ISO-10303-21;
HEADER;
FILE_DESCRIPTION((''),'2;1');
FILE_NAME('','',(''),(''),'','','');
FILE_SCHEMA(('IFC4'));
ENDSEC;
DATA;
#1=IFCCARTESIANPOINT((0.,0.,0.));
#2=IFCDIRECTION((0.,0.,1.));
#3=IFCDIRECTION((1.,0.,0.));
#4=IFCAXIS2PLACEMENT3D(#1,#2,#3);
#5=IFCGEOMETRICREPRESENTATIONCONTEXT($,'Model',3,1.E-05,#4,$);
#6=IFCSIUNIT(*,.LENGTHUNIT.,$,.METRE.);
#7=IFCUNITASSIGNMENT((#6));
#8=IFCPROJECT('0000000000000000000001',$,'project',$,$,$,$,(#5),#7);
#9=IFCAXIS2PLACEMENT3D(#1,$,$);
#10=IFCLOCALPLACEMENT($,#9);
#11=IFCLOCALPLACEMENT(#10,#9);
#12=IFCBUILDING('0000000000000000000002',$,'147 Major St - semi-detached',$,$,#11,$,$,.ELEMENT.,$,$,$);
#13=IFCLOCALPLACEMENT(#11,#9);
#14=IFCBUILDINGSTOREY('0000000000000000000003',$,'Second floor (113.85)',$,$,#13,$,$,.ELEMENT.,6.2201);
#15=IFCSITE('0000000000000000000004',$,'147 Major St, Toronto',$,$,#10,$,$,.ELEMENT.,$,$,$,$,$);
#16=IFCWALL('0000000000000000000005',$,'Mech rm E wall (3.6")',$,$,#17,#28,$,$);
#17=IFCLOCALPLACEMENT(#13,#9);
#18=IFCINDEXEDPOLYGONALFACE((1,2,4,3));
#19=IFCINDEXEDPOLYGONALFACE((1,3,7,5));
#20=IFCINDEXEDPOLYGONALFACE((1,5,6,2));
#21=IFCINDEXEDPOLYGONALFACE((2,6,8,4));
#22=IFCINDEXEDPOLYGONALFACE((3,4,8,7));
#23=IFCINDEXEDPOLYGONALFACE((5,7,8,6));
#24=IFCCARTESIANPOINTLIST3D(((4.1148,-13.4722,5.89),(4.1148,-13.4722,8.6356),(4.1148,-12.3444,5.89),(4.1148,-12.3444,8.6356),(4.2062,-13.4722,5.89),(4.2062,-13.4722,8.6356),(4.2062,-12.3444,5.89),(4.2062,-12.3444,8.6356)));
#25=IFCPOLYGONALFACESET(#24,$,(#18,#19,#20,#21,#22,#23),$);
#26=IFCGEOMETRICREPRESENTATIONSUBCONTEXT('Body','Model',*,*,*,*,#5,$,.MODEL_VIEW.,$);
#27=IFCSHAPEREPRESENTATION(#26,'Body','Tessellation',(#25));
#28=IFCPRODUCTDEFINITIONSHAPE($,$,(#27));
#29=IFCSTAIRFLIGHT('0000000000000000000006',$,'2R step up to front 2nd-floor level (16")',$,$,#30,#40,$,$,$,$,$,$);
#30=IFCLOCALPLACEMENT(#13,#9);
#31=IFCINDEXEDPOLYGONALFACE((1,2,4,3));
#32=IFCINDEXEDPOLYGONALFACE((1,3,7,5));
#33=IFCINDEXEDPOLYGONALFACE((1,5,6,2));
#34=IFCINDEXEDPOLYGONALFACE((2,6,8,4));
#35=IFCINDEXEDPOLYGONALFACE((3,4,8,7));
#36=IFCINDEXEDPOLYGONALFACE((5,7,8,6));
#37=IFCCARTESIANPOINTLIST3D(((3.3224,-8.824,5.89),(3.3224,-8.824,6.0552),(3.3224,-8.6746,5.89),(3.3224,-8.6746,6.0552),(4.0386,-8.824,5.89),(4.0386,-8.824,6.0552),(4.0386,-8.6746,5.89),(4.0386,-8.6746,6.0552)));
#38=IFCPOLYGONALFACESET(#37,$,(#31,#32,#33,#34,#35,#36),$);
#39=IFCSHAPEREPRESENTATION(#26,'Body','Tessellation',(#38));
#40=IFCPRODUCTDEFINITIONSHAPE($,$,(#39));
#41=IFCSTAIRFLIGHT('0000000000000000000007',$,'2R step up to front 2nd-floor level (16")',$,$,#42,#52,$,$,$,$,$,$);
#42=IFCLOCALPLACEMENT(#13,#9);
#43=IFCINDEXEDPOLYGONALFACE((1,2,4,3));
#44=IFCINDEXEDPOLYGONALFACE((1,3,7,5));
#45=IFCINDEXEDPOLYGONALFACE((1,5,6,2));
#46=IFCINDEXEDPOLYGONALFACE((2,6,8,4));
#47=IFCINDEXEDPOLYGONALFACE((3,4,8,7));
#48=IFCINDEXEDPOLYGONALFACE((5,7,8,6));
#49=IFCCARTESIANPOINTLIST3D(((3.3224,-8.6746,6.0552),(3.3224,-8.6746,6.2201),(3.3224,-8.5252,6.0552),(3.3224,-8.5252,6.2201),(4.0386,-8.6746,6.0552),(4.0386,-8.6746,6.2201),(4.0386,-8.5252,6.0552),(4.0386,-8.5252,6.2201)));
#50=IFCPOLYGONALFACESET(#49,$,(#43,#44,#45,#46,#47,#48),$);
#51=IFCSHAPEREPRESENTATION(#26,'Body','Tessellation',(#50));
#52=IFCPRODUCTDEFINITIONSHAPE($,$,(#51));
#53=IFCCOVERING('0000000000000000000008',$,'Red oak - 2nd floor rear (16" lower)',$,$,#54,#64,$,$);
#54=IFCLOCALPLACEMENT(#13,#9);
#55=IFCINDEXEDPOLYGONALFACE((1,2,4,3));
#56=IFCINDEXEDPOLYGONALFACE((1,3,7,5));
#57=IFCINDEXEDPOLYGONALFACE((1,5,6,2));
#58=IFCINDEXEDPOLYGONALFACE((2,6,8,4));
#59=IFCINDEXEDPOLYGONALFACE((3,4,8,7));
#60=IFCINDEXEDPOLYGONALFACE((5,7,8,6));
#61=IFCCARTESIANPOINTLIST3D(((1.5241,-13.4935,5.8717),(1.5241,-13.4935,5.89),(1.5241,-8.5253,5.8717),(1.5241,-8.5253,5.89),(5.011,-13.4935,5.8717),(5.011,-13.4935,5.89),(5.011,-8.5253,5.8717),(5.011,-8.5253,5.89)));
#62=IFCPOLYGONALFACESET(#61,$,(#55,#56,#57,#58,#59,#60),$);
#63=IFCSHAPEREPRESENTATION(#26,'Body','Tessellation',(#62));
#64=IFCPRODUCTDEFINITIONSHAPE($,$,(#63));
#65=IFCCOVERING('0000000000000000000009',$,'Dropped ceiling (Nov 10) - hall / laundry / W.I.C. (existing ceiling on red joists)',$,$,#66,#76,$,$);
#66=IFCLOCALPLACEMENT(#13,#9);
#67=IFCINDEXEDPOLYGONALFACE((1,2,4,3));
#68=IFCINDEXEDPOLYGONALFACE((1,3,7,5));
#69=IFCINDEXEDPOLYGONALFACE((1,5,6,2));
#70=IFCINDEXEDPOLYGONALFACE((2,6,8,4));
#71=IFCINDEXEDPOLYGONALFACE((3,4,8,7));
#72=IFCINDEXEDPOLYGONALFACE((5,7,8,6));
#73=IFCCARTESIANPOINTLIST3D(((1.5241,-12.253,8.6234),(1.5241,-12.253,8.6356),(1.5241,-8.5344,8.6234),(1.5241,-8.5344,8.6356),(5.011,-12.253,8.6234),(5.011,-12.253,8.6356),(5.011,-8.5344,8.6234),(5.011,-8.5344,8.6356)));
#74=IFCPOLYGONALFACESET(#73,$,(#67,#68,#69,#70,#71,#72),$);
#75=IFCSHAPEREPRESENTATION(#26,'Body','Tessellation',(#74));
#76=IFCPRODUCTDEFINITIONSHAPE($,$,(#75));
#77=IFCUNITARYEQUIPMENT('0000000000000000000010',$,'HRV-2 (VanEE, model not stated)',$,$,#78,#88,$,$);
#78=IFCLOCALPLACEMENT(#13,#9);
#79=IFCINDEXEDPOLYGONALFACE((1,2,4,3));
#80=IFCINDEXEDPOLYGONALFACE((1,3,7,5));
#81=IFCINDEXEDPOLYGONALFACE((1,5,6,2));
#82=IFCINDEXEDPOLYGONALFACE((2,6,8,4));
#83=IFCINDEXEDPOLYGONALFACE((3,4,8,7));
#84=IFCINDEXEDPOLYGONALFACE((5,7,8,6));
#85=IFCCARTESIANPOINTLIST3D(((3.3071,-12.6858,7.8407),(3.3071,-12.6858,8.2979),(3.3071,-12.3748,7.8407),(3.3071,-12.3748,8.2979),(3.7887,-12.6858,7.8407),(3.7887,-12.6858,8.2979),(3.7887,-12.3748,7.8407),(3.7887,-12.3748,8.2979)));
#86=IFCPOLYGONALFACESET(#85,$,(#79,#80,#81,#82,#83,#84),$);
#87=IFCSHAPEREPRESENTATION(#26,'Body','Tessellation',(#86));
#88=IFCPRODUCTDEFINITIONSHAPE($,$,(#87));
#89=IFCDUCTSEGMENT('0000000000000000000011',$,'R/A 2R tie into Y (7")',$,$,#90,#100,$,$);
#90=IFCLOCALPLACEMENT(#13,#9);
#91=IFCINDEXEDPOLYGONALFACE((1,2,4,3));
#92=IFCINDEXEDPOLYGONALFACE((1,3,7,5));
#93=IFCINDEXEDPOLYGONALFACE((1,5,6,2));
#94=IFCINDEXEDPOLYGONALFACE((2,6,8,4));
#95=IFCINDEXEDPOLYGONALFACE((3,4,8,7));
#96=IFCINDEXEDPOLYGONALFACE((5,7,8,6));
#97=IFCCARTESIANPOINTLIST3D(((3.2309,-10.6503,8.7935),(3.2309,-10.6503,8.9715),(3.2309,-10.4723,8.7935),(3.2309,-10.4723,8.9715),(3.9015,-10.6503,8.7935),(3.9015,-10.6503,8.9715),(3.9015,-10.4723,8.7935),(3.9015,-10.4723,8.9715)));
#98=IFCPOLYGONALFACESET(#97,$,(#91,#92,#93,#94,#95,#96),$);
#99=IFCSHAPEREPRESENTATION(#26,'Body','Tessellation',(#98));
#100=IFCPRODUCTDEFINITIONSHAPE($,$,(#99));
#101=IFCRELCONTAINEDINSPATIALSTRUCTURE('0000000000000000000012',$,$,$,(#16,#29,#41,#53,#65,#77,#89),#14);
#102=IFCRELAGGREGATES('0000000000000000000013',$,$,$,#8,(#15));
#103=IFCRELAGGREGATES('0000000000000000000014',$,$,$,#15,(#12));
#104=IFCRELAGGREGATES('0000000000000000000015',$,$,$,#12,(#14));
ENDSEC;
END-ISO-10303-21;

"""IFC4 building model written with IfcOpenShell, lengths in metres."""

from ifc_helpers import new_model, si_unit, frame, origin, origin_with_axes, place, context, subcontext, project, spatial, rectangle, extrude, element, save


model = new_model("IFC4")

# Units and contexts
model_context = context("Model", 3, precision=1e-05, world=origin_with_axes())
body_context = subcontext(model_context, "Body", "Model", "MODEL_VIEW")
ifc_project = project(units=[si_unit("LENGTHUNIT", "METRE")], contexts=[model_context])

# Site, building, storey
site_placement = place(None, origin())
site = spatial("IfcSite", under=ifc_project, at=site_placement, Name="147 Major St, Toronto", CompositionType="ELEMENT")
building_placement = place(site_placement, origin())
building = spatial("IfcBuilding", under=site, at=building_placement, Name="147 Major St - semi-detached", CompositionType="ELEMENT")
storey_placement = place(building_placement, origin())
storey = spatial("IfcBuildingStorey", under=building, at=storey_placement, Name="Second floor (113.85)", CompositionType="ELEMENT", Elevation=6.2201)

# Wall
wall_1_placement = place(storey_placement, frame((4.1605, -12.9083, 5.89)))
element("IfcWall", 1, at=wall_1_placement, inside=storey, Name="Mech rm E wall (3.6\")", context=body_context, shape_type="SweptSolid", body=[
    extrude(rectangle(XDim=0.0914, YDim=1.1278), origin_with_axes(), (0.0, 0.0, 1.0), 2.7456),
])

# Stair flights
stair_flight_1_placement = place(storey_placement, frame((3.6805, -8.7493, 5.89)))
element("IfcStairFlight", 2, at=stair_flight_1_placement, inside=storey, Name="2R step up to front 2nd-floor level (16\")", context=body_context, shape_type="SweptSolid", body=[
    extrude(rectangle(XDim=0.7163, YDim=0.1494), origin_with_axes(), (0.0, 0.0, 1.0), 0.1652),
])
stair_flight_2_placement = place(storey_placement, frame((3.6805, -8.5999, 6.0552)))
element("IfcStairFlight", 3, at=stair_flight_2_placement, inside=storey, Name="2R step up to front 2nd-floor level (16\")", context=body_context, shape_type="SweptSolid", body=[
    extrude(rectangle(XDim=0.7163, YDim=0.1494), origin_with_axes(), (0.0, 0.0, 1.0), 0.1649),
])

# Coverings
covering_placement = place(storey_placement, frame((3.2675, -11.0094, 5.8717)))
element("IfcCovering", 4, at=covering_placement, inside=storey, Name="Red oak - 2nd floor rear (16\" lower)", context=body_context, shape_type="SweptSolid", body=[
    extrude(rectangle(XDim=3.4869, YDim=4.9682), origin_with_axes(), (0.0, 0.0, 1.0), 0.0183),
])
for number, where, name in (
    (5, (3.2675, -10.3937, 8.6234), "Dropped ceiling (Nov 10) - hall / laundry / W.I.C. (existing ceiling on red joists)"),
):
    element("IfcCovering", number, at=place(storey_placement, frame(where)), inside=storey, Name=name, context=body_context, shape_type="SweptSolid", body=[
        extrude(rectangle(XDim=3.4869, YDim=3.7186), origin_with_axes(), (0.0, 0.0, 1.0), 0.0122),
    ])

# Unitary equipment
unitary_equipment_placement = place(storey_placement, frame((3.5479, -12.5303, 7.8407)))
element("IfcUnitaryEquipment", 6, at=unitary_equipment_placement, inside=storey, Name="HRV-2 (VanEE, model not stated)", context=body_context, shape_type="SweptSolid", body=[
    extrude(rectangle(XDim=0.4816, YDim=0.3109), origin_with_axes(), (0.0, 0.0, 1.0), 0.4572),
])

# Duct segment
duct_segment_placement = place(storey_placement, frame((3.5662, -10.5613, 8.7935)))
element("IfcDuctSegment", 7, at=duct_segment_placement, inside=storey, Name="R/A 2R tie into Y (7\")", context=body_context, shape_type="SweptSolid", body=[
    extrude(rectangle(XDim=0.6706, YDim=0.178), origin_with_axes(), (0.0, 0.0, 1.0), 0.178),
])

save(model, "model.ifc")
